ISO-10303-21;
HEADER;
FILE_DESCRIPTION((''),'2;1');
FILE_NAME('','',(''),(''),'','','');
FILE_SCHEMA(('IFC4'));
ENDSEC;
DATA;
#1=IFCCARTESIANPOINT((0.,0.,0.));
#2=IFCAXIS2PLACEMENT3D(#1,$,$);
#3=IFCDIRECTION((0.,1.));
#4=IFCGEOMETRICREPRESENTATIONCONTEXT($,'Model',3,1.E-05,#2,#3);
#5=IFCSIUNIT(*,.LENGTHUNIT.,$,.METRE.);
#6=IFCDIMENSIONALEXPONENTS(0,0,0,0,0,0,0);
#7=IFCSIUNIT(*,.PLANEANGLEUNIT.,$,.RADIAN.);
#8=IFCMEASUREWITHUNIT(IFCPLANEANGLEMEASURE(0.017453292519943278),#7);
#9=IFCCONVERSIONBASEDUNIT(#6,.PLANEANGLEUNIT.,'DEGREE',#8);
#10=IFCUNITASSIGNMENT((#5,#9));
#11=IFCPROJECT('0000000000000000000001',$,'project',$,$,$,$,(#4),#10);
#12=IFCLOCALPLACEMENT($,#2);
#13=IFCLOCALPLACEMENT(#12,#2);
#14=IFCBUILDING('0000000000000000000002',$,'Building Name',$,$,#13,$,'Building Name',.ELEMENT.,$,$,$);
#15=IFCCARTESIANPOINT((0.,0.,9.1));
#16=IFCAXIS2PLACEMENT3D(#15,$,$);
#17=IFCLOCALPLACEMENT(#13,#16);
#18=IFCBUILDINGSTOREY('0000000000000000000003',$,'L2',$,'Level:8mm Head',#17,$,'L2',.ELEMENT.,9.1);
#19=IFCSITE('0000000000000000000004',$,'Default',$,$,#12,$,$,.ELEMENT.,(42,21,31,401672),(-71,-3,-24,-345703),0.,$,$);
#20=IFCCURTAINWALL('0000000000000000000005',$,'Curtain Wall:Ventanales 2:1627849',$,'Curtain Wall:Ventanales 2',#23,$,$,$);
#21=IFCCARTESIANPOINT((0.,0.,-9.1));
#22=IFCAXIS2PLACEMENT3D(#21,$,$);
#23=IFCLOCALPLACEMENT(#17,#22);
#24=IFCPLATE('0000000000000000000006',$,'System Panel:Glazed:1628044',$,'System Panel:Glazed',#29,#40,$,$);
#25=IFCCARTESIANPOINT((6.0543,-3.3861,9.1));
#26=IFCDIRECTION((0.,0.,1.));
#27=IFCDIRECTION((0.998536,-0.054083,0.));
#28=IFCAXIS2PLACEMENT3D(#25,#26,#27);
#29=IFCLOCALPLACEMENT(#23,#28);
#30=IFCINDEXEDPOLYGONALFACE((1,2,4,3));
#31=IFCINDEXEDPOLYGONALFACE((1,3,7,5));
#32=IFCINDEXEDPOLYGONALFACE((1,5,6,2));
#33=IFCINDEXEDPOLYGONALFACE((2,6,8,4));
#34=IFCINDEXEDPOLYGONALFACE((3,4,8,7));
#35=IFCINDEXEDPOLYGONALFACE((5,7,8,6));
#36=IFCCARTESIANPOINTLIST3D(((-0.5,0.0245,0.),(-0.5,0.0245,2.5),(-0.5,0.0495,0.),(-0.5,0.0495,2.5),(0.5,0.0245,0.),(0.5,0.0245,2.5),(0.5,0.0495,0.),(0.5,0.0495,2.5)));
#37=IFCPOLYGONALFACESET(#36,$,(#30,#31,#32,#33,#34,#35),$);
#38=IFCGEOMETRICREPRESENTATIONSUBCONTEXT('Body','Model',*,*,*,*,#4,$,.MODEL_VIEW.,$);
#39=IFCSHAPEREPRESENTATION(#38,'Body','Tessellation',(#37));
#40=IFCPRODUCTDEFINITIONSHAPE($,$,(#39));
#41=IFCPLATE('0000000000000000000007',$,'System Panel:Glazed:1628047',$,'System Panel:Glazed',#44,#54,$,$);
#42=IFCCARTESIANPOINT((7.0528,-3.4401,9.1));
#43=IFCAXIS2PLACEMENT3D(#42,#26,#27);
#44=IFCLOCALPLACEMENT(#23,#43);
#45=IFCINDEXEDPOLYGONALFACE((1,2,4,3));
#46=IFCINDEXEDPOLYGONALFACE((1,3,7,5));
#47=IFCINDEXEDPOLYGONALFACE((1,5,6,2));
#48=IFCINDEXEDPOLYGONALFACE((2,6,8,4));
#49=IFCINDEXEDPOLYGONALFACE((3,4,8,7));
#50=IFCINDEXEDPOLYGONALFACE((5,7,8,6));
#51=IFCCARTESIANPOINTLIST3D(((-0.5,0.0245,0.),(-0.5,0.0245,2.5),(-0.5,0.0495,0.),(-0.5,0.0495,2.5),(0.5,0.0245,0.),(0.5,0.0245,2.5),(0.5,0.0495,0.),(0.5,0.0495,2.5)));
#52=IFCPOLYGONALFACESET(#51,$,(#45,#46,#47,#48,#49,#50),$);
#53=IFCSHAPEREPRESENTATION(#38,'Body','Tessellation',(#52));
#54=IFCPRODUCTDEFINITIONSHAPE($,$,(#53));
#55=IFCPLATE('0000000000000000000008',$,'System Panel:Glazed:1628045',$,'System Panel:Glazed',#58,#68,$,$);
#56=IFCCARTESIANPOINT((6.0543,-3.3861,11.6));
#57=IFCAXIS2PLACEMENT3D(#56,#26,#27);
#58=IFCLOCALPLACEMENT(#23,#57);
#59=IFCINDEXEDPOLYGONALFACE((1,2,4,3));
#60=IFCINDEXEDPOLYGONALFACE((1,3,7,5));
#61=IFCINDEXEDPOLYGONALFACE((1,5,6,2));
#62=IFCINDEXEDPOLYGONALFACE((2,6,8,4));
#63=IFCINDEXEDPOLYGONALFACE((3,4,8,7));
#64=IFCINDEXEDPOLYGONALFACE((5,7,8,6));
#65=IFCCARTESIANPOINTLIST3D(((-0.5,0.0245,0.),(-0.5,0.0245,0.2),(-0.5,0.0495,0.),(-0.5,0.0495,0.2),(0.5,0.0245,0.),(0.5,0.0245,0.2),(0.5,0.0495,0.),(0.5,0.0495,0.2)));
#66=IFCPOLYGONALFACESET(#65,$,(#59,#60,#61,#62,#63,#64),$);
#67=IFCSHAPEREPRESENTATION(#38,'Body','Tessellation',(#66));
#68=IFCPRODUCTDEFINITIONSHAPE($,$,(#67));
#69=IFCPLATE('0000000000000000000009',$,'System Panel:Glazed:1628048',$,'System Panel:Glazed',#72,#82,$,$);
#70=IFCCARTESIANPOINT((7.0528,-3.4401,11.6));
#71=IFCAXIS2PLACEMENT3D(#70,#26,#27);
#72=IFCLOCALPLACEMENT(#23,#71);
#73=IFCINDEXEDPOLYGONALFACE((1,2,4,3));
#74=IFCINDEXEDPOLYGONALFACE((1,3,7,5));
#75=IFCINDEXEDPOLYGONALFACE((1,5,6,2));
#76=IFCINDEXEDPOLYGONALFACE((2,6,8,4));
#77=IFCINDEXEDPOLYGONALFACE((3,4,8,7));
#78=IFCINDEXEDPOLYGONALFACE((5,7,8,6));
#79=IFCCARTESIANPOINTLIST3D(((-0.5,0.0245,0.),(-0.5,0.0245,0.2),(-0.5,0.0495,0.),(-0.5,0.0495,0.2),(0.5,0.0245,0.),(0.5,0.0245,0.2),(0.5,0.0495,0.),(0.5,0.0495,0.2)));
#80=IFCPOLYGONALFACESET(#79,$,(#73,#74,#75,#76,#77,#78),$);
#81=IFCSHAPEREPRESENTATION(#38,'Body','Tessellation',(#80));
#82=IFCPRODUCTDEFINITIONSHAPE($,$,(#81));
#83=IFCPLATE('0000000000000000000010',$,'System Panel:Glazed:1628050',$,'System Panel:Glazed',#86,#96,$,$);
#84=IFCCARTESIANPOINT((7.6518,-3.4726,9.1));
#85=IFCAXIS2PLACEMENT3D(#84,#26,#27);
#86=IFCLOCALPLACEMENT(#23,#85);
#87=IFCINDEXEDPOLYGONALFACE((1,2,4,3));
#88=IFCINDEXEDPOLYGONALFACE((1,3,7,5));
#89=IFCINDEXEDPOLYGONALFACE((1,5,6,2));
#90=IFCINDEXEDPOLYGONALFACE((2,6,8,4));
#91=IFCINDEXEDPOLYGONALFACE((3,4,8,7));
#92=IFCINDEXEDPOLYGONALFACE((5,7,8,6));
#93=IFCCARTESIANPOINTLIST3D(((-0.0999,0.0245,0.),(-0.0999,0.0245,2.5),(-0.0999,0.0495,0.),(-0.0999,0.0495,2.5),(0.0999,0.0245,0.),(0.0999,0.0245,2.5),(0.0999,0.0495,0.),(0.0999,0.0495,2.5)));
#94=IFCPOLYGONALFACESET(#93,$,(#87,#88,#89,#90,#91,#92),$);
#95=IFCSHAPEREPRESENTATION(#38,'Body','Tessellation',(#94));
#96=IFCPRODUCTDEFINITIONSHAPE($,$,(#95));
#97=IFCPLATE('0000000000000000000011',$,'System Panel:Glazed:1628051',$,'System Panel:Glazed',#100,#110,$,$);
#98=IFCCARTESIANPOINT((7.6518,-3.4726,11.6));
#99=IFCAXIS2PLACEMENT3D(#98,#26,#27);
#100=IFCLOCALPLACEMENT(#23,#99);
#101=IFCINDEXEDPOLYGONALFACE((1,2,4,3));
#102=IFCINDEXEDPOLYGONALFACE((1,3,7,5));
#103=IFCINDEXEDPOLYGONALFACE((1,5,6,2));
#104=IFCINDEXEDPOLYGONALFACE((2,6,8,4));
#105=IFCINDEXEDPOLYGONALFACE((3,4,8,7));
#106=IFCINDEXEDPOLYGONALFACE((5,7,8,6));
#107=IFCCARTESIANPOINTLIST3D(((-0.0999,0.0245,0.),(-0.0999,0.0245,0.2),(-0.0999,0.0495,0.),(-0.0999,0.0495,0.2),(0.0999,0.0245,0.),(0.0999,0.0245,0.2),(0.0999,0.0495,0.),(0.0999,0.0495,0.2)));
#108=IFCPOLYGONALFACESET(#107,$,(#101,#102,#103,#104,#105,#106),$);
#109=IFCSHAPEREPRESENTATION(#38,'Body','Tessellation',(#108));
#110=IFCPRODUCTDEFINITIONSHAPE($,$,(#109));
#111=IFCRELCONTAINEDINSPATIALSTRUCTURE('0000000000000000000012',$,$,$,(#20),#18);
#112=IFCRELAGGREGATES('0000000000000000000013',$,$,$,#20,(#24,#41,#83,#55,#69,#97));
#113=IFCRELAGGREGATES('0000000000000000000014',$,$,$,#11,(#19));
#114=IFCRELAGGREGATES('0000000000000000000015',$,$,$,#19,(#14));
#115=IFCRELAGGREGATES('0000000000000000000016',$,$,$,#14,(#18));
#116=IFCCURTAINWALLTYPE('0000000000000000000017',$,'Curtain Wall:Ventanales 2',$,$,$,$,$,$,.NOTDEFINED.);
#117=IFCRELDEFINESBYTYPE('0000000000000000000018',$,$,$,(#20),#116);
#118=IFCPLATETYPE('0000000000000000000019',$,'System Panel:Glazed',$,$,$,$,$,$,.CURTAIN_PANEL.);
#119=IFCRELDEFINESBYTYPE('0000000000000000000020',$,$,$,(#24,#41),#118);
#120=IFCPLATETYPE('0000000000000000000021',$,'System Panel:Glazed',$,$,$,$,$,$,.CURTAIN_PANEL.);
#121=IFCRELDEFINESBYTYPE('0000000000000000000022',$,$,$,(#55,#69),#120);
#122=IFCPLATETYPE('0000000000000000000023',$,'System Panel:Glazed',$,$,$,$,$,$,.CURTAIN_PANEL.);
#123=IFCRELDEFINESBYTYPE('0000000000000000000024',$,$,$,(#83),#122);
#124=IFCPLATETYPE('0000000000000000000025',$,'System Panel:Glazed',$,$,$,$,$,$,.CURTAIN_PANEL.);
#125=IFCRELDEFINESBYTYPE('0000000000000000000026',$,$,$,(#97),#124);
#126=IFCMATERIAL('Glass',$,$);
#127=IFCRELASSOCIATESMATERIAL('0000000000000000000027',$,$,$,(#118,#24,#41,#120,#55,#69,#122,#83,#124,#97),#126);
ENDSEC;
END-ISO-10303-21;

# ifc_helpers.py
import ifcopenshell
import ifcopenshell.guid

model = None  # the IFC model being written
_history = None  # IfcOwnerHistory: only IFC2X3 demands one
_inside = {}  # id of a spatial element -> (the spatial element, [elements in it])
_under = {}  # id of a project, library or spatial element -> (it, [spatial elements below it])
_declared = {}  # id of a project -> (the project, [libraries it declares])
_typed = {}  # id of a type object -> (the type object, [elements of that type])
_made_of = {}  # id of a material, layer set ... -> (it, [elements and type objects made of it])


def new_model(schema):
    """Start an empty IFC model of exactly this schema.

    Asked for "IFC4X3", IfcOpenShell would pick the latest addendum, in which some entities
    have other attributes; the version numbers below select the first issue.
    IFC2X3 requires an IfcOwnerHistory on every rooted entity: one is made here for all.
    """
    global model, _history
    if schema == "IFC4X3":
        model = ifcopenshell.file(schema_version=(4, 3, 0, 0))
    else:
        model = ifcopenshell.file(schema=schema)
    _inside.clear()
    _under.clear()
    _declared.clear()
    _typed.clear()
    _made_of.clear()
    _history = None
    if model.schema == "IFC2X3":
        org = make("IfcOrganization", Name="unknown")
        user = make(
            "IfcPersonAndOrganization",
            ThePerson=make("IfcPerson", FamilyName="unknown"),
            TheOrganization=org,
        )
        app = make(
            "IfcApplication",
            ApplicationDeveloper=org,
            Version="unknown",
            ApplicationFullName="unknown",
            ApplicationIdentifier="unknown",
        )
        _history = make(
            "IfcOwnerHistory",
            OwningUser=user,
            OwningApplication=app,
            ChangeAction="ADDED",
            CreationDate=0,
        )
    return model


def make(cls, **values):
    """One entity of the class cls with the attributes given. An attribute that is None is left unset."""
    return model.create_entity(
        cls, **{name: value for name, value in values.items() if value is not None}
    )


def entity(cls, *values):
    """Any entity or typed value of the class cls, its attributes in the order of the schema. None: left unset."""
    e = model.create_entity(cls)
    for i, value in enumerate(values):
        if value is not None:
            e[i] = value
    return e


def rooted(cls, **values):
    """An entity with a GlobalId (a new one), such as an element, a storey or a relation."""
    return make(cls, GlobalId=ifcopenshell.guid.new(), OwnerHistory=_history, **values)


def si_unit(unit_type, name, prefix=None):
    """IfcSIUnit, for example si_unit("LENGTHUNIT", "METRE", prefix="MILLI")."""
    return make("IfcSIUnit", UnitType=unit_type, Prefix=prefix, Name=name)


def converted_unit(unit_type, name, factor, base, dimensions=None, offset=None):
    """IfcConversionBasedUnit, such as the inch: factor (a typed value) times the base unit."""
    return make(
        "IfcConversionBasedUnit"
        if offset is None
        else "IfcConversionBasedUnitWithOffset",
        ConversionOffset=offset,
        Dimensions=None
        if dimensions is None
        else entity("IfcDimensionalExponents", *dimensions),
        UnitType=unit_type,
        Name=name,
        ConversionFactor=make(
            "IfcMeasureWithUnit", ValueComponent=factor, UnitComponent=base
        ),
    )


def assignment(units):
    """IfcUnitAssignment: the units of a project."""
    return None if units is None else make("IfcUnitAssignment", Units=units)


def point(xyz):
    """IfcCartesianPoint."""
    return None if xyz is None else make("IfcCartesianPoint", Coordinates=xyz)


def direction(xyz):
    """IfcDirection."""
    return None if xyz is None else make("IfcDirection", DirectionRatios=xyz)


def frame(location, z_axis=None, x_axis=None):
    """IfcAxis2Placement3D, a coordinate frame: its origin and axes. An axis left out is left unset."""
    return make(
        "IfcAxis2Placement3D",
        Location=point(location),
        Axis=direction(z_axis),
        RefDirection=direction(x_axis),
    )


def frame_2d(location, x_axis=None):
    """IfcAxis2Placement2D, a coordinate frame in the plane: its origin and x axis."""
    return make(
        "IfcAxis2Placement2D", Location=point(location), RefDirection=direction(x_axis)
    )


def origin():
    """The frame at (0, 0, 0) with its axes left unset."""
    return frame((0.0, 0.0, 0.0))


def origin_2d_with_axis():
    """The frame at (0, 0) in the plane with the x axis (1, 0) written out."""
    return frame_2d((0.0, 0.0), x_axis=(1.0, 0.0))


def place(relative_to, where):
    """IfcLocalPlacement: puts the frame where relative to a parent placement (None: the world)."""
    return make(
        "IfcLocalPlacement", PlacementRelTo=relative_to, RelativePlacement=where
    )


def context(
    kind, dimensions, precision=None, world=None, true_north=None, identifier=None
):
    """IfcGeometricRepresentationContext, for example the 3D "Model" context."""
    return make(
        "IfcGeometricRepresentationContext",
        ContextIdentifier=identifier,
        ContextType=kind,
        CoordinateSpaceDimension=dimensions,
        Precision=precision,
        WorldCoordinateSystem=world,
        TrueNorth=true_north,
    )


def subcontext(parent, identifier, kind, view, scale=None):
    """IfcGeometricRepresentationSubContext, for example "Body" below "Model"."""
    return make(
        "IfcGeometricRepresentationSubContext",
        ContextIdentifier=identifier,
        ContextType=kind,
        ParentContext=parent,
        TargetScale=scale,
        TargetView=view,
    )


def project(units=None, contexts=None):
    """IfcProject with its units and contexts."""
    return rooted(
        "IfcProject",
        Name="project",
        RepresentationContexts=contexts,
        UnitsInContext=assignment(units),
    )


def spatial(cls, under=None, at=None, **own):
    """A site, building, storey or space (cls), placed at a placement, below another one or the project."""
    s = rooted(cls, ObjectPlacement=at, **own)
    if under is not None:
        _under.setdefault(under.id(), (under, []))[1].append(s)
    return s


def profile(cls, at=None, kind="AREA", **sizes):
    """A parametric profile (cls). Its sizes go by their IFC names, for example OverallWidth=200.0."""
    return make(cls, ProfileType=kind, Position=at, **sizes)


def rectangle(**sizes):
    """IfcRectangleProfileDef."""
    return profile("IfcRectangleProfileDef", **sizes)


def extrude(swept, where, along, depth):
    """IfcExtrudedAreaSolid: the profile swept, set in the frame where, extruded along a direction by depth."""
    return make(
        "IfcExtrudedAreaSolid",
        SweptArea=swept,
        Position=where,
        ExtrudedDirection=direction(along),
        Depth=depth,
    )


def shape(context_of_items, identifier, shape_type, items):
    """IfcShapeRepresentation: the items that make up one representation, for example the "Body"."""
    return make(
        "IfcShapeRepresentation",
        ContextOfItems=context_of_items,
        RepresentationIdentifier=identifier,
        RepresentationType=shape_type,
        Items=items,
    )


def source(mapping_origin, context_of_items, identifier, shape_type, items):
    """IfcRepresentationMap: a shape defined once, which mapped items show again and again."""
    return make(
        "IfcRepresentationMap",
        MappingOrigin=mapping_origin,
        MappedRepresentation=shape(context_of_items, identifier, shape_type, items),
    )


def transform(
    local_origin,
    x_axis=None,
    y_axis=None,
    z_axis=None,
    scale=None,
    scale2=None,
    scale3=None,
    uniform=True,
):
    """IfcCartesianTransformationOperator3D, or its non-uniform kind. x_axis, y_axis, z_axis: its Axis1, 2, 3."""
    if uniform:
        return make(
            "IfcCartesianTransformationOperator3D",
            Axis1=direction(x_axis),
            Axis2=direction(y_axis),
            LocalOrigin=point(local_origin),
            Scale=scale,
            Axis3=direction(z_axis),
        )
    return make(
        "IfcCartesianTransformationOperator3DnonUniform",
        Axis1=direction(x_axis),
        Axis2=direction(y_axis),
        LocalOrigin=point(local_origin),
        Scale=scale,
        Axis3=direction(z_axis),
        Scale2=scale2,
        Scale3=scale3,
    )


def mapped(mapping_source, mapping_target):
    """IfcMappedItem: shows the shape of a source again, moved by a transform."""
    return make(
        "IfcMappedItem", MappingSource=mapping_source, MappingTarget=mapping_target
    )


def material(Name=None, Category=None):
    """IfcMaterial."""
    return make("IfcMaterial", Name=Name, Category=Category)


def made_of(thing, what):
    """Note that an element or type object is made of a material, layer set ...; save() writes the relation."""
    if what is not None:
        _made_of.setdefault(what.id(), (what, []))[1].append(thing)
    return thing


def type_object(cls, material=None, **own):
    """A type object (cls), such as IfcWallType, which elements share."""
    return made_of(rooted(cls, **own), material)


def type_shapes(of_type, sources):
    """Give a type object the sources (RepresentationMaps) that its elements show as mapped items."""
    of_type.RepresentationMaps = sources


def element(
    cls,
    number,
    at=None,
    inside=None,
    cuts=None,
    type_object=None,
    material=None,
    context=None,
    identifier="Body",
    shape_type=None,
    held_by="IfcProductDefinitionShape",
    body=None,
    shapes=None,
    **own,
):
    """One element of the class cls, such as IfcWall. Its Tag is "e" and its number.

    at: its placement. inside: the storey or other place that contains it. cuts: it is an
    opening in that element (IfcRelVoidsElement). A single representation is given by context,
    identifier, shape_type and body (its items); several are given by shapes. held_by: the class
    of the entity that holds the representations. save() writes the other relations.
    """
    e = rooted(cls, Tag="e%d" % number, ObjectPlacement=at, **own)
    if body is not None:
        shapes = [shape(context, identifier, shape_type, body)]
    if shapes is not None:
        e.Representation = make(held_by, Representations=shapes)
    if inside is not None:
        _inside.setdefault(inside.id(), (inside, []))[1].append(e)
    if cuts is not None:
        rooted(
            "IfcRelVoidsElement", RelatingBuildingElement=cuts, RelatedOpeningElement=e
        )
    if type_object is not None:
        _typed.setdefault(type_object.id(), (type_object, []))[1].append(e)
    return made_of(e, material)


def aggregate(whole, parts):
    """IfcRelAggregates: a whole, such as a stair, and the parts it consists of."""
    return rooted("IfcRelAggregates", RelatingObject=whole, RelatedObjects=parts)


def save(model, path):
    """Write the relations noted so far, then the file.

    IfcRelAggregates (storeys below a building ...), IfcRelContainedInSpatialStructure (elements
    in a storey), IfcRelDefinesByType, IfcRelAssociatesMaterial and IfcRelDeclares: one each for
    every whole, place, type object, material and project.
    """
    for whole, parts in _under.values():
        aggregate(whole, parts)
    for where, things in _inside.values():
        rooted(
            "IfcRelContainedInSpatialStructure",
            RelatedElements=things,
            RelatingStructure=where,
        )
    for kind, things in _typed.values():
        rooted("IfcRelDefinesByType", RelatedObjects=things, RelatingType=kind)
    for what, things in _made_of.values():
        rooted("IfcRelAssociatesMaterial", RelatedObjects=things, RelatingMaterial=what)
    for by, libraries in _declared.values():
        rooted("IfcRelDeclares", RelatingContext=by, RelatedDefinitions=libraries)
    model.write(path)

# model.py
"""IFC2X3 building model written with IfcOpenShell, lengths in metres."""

from ifc_helpers import new_model, entity, si_unit, converted_unit, direction, frame, frame_2d, origin, origin_2d_with_axis, place, context, subcontext, project, spatial, rectangle, extrude, source, transform, mapped, material, type_object, type_shapes, element, aggregate, save


model = new_model("IFC2X3")

# Units and contexts
model_context = context("Model", 3, precision=1e-05, world=origin(), true_north=direction((0.0, 1.0)))
body_context = subcontext(model_context, "Body", "Model", "MODEL_VIEW")
ifc_project = project(units=[si_unit("LENGTHUNIT", "METRE"), converted_unit("PLANEANGLEUNIT", "DEGREE", entity("IfcPlaneAngleMeasure", 0.017453292519943278), si_unit("PLANEANGLEUNIT", "RADIAN"), dimensions=[0, 0, 0, 0, 0, 0, 0])], contexts=[model_context])

# Site, building, storey
site_placement = place(None, origin())
site = spatial("IfcSite", under=ifc_project, at=site_placement, Name="Default", CompositionType="ELEMENT", RefLatitude=(42, 21, 31, 401672), RefLongitude=(-71, -3, -24, -345703), RefElevation=0.0)
building_placement = place(site_placement, origin())
building = spatial("IfcBuilding", under=site, at=building_placement, Name="Building Name", LongName="Building Name", CompositionType="ELEMENT")
storey_placement = place(building_placement, frame((0.0, 0.0, 9.1)))
storey = spatial("IfcBuildingStorey", under=building, at=storey_placement, Name="L2", ObjectType="Level:8mm Head", LongName="L2", CompositionType="ELEMENT", Elevation=9.1)

# Curtain wall, plates
curtain_wall_type = type_object("IfcCurtainWallType", Name="Curtain Wall:Ventanales 2", PredefinedType="NOTDEFINED")
curtain_wall_placement = place(storey_placement, frame((0.0, 0.0, -9.1)))
curtain_wall = element("IfcCurtainWall", 1, at=curtain_wall_placement, inside=storey, type_object=curtain_wall_type, Name="Curtain Wall:Ventanales 2:1627849", ObjectType="Curtain Wall:Ventanales 2")
ifc_material_1 = material(Name="Glass")
plate_type_1 = type_object("IfcPlateType", Name="System Panel:Glazed", PredefinedType="CURTAIN_PANEL", material=ifc_material_1)
shared_shape_1 = source(origin(), body_context, "Body", "SweptSolid", [
    extrude(rectangle(XDim=0.025, YDim=1.0, at=origin_2d_with_axis()), frame((0.0, 0.037, 0.0), z_axis=(0.0, 0.0, 1.0), x_axis=(0.0, 1.0, 0.0)), (0.0, 0.0, 1.0), 2.5),
])
type_shapes(plate_type_1, [shared_shape_1])
plate_1_placement = place(curtain_wall_placement, frame((6.0543, -3.3861, 9.1), z_axis=(0.0, 0.0, 1.0), x_axis=(0.998536, -0.054083, 0.0)))
plate_1 = element("IfcPlate", 2, at=plate_1_placement, type_object=plate_type_1, material=ifc_material_1, Name="System Panel:Glazed:1628044", ObjectType="System Panel:Glazed", context=body_context, shape_type="MappedRepresentation", body=[
    mapped(shared_shape_1, transform((0.0, 0.0, 0.0), scale=1.0)),
])
plate_2_placement = place(curtain_wall_placement, frame((7.0528, -3.4401, 9.1), z_axis=(0.0, 0.0, 1.0), x_axis=(0.998536, -0.054083, 0.0)))
plate_2 = element("IfcPlate", 3, at=plate_2_placement, type_object=plate_type_1, material=ifc_material_1, Name="System Panel:Glazed:1628047", ObjectType="System Panel:Glazed", context=body_context, shape_type="MappedRepresentation", body=[
    mapped(shared_shape_1, transform((0.0, 0.0, 0.0), scale=1.0)),
])
plate_type_2 = type_object("IfcPlateType", Name="System Panel:Glazed", PredefinedType="CURTAIN_PANEL", material=ifc_material_1)
shared_shape_2 = source(origin(), body_context, "Body", "SweptSolid", [
    extrude(rectangle(XDim=0.025, YDim=1.0, at=origin_2d_with_axis()), frame((0.0, 0.037, 0.0), z_axis=(0.0, 0.0, 1.0), x_axis=(0.0, 1.0, 0.0)), (0.0, 0.0, 1.0), 0.2),
])
type_shapes(plate_type_2, [shared_shape_2])
plate_3_placement = place(curtain_wall_placement, frame((6.0543, -3.3861, 11.6), z_axis=(0.0, 0.0, 1.0), x_axis=(0.998536, -0.054083, 0.0)))
plate_3 = element("IfcPlate", 4, at=plate_3_placement, type_object=plate_type_2, material=ifc_material_1, Name="System Panel:Glazed:1628045", ObjectType="System Panel:Glazed", context=body_context, shape_type="MappedRepresentation", body=[
    mapped(shared_shape_2, transform((0.0, 0.0, 0.0), scale=1.0)),
])
plate_4_placement = place(curtain_wall_placement, frame((7.0528, -3.4401, 11.6), z_axis=(0.0, 0.0, 1.0), x_axis=(0.998536, -0.054083, 0.0)))
plate_4 = element("IfcPlate", 5, at=plate_4_placement, type_object=plate_type_2, material=ifc_material_1, Name="System Panel:Glazed:1628048", ObjectType="System Panel:Glazed", context=body_context, shape_type="MappedRepresentation", body=[
    mapped(shared_shape_2, transform((0.0, 0.0, 0.0), scale=1.0)),
])
plate_type_3 = type_object("IfcPlateType", Name="System Panel:Glazed", PredefinedType="CURTAIN_PANEL", material=ifc_material_1)
shared_shape_3 = source(origin(), body_context, "Body", "SweptSolid", [
    extrude(rectangle(XDim=0.025, YDim=0.1998, at=frame_2d((0.0, 0.0), x_axis=(1.0, 0.0))), frame((0.0, 0.037, 0.0), z_axis=(0.0, 0.0, 1.0), x_axis=(0.0, 1.0, 0.0)), (0.0, 0.0, 1.0), 2.5),
])
type_shapes(plate_type_3, [shared_shape_3])
plate_5_placement = place(curtain_wall_placement, frame((7.6518, -3.4726, 9.1), z_axis=(0.0, 0.0, 1.0), x_axis=(0.998536, -0.054083, 0.0)))
plate_5 = element("IfcPlate", 6, at=plate_5_placement, type_object=plate_type_3, material=ifc_material_1, Name="System Panel:Glazed:1628050", ObjectType="System Panel:Glazed", context=body_context, shape_type="MappedRepresentation", body=[
    mapped(shared_shape_3, transform((0.0, 0.0, 0.0), scale=1.0)),
])
plate_type_4 = type_object("IfcPlateType", Name="System Panel:Glazed", PredefinedType="CURTAIN_PANEL", material=ifc_material_1)
shared_shape_4 = source(origin(), body_context, "Body", "SweptSolid", [
    extrude(rectangle(XDim=0.025, YDim=0.1998, at=frame_2d((0.0, 0.0), x_axis=(1.0, 0.0))), frame((0.0, 0.037, 0.0), z_axis=(0.0, 0.0, 1.0), x_axis=(0.0, 1.0, 0.0)), (0.0, 0.0, 1.0), 0.2),
])
type_shapes(plate_type_4, [shared_shape_4])
plate_6_placement = place(curtain_wall_placement, frame((7.6518, -3.4726, 11.6), z_axis=(0.0, 0.0, 1.0), x_axis=(0.998536, -0.054083, 0.0)))
plate_6 = element("IfcPlate", 7, at=plate_6_placement, type_object=plate_type_4, material=ifc_material_1, Name="System Panel:Glazed:1628051", ObjectType="System Panel:Glazed", context=body_context, shape_type="MappedRepresentation", body=[
    mapped(shared_shape_4, transform((0.0, 0.0, 0.0), scale=1.0)),
])
aggregate(curtain_wall, [plate_1, plate_2, plate_5, plate_3, plate_4, plate_6])

save(model, "model.ifc")
